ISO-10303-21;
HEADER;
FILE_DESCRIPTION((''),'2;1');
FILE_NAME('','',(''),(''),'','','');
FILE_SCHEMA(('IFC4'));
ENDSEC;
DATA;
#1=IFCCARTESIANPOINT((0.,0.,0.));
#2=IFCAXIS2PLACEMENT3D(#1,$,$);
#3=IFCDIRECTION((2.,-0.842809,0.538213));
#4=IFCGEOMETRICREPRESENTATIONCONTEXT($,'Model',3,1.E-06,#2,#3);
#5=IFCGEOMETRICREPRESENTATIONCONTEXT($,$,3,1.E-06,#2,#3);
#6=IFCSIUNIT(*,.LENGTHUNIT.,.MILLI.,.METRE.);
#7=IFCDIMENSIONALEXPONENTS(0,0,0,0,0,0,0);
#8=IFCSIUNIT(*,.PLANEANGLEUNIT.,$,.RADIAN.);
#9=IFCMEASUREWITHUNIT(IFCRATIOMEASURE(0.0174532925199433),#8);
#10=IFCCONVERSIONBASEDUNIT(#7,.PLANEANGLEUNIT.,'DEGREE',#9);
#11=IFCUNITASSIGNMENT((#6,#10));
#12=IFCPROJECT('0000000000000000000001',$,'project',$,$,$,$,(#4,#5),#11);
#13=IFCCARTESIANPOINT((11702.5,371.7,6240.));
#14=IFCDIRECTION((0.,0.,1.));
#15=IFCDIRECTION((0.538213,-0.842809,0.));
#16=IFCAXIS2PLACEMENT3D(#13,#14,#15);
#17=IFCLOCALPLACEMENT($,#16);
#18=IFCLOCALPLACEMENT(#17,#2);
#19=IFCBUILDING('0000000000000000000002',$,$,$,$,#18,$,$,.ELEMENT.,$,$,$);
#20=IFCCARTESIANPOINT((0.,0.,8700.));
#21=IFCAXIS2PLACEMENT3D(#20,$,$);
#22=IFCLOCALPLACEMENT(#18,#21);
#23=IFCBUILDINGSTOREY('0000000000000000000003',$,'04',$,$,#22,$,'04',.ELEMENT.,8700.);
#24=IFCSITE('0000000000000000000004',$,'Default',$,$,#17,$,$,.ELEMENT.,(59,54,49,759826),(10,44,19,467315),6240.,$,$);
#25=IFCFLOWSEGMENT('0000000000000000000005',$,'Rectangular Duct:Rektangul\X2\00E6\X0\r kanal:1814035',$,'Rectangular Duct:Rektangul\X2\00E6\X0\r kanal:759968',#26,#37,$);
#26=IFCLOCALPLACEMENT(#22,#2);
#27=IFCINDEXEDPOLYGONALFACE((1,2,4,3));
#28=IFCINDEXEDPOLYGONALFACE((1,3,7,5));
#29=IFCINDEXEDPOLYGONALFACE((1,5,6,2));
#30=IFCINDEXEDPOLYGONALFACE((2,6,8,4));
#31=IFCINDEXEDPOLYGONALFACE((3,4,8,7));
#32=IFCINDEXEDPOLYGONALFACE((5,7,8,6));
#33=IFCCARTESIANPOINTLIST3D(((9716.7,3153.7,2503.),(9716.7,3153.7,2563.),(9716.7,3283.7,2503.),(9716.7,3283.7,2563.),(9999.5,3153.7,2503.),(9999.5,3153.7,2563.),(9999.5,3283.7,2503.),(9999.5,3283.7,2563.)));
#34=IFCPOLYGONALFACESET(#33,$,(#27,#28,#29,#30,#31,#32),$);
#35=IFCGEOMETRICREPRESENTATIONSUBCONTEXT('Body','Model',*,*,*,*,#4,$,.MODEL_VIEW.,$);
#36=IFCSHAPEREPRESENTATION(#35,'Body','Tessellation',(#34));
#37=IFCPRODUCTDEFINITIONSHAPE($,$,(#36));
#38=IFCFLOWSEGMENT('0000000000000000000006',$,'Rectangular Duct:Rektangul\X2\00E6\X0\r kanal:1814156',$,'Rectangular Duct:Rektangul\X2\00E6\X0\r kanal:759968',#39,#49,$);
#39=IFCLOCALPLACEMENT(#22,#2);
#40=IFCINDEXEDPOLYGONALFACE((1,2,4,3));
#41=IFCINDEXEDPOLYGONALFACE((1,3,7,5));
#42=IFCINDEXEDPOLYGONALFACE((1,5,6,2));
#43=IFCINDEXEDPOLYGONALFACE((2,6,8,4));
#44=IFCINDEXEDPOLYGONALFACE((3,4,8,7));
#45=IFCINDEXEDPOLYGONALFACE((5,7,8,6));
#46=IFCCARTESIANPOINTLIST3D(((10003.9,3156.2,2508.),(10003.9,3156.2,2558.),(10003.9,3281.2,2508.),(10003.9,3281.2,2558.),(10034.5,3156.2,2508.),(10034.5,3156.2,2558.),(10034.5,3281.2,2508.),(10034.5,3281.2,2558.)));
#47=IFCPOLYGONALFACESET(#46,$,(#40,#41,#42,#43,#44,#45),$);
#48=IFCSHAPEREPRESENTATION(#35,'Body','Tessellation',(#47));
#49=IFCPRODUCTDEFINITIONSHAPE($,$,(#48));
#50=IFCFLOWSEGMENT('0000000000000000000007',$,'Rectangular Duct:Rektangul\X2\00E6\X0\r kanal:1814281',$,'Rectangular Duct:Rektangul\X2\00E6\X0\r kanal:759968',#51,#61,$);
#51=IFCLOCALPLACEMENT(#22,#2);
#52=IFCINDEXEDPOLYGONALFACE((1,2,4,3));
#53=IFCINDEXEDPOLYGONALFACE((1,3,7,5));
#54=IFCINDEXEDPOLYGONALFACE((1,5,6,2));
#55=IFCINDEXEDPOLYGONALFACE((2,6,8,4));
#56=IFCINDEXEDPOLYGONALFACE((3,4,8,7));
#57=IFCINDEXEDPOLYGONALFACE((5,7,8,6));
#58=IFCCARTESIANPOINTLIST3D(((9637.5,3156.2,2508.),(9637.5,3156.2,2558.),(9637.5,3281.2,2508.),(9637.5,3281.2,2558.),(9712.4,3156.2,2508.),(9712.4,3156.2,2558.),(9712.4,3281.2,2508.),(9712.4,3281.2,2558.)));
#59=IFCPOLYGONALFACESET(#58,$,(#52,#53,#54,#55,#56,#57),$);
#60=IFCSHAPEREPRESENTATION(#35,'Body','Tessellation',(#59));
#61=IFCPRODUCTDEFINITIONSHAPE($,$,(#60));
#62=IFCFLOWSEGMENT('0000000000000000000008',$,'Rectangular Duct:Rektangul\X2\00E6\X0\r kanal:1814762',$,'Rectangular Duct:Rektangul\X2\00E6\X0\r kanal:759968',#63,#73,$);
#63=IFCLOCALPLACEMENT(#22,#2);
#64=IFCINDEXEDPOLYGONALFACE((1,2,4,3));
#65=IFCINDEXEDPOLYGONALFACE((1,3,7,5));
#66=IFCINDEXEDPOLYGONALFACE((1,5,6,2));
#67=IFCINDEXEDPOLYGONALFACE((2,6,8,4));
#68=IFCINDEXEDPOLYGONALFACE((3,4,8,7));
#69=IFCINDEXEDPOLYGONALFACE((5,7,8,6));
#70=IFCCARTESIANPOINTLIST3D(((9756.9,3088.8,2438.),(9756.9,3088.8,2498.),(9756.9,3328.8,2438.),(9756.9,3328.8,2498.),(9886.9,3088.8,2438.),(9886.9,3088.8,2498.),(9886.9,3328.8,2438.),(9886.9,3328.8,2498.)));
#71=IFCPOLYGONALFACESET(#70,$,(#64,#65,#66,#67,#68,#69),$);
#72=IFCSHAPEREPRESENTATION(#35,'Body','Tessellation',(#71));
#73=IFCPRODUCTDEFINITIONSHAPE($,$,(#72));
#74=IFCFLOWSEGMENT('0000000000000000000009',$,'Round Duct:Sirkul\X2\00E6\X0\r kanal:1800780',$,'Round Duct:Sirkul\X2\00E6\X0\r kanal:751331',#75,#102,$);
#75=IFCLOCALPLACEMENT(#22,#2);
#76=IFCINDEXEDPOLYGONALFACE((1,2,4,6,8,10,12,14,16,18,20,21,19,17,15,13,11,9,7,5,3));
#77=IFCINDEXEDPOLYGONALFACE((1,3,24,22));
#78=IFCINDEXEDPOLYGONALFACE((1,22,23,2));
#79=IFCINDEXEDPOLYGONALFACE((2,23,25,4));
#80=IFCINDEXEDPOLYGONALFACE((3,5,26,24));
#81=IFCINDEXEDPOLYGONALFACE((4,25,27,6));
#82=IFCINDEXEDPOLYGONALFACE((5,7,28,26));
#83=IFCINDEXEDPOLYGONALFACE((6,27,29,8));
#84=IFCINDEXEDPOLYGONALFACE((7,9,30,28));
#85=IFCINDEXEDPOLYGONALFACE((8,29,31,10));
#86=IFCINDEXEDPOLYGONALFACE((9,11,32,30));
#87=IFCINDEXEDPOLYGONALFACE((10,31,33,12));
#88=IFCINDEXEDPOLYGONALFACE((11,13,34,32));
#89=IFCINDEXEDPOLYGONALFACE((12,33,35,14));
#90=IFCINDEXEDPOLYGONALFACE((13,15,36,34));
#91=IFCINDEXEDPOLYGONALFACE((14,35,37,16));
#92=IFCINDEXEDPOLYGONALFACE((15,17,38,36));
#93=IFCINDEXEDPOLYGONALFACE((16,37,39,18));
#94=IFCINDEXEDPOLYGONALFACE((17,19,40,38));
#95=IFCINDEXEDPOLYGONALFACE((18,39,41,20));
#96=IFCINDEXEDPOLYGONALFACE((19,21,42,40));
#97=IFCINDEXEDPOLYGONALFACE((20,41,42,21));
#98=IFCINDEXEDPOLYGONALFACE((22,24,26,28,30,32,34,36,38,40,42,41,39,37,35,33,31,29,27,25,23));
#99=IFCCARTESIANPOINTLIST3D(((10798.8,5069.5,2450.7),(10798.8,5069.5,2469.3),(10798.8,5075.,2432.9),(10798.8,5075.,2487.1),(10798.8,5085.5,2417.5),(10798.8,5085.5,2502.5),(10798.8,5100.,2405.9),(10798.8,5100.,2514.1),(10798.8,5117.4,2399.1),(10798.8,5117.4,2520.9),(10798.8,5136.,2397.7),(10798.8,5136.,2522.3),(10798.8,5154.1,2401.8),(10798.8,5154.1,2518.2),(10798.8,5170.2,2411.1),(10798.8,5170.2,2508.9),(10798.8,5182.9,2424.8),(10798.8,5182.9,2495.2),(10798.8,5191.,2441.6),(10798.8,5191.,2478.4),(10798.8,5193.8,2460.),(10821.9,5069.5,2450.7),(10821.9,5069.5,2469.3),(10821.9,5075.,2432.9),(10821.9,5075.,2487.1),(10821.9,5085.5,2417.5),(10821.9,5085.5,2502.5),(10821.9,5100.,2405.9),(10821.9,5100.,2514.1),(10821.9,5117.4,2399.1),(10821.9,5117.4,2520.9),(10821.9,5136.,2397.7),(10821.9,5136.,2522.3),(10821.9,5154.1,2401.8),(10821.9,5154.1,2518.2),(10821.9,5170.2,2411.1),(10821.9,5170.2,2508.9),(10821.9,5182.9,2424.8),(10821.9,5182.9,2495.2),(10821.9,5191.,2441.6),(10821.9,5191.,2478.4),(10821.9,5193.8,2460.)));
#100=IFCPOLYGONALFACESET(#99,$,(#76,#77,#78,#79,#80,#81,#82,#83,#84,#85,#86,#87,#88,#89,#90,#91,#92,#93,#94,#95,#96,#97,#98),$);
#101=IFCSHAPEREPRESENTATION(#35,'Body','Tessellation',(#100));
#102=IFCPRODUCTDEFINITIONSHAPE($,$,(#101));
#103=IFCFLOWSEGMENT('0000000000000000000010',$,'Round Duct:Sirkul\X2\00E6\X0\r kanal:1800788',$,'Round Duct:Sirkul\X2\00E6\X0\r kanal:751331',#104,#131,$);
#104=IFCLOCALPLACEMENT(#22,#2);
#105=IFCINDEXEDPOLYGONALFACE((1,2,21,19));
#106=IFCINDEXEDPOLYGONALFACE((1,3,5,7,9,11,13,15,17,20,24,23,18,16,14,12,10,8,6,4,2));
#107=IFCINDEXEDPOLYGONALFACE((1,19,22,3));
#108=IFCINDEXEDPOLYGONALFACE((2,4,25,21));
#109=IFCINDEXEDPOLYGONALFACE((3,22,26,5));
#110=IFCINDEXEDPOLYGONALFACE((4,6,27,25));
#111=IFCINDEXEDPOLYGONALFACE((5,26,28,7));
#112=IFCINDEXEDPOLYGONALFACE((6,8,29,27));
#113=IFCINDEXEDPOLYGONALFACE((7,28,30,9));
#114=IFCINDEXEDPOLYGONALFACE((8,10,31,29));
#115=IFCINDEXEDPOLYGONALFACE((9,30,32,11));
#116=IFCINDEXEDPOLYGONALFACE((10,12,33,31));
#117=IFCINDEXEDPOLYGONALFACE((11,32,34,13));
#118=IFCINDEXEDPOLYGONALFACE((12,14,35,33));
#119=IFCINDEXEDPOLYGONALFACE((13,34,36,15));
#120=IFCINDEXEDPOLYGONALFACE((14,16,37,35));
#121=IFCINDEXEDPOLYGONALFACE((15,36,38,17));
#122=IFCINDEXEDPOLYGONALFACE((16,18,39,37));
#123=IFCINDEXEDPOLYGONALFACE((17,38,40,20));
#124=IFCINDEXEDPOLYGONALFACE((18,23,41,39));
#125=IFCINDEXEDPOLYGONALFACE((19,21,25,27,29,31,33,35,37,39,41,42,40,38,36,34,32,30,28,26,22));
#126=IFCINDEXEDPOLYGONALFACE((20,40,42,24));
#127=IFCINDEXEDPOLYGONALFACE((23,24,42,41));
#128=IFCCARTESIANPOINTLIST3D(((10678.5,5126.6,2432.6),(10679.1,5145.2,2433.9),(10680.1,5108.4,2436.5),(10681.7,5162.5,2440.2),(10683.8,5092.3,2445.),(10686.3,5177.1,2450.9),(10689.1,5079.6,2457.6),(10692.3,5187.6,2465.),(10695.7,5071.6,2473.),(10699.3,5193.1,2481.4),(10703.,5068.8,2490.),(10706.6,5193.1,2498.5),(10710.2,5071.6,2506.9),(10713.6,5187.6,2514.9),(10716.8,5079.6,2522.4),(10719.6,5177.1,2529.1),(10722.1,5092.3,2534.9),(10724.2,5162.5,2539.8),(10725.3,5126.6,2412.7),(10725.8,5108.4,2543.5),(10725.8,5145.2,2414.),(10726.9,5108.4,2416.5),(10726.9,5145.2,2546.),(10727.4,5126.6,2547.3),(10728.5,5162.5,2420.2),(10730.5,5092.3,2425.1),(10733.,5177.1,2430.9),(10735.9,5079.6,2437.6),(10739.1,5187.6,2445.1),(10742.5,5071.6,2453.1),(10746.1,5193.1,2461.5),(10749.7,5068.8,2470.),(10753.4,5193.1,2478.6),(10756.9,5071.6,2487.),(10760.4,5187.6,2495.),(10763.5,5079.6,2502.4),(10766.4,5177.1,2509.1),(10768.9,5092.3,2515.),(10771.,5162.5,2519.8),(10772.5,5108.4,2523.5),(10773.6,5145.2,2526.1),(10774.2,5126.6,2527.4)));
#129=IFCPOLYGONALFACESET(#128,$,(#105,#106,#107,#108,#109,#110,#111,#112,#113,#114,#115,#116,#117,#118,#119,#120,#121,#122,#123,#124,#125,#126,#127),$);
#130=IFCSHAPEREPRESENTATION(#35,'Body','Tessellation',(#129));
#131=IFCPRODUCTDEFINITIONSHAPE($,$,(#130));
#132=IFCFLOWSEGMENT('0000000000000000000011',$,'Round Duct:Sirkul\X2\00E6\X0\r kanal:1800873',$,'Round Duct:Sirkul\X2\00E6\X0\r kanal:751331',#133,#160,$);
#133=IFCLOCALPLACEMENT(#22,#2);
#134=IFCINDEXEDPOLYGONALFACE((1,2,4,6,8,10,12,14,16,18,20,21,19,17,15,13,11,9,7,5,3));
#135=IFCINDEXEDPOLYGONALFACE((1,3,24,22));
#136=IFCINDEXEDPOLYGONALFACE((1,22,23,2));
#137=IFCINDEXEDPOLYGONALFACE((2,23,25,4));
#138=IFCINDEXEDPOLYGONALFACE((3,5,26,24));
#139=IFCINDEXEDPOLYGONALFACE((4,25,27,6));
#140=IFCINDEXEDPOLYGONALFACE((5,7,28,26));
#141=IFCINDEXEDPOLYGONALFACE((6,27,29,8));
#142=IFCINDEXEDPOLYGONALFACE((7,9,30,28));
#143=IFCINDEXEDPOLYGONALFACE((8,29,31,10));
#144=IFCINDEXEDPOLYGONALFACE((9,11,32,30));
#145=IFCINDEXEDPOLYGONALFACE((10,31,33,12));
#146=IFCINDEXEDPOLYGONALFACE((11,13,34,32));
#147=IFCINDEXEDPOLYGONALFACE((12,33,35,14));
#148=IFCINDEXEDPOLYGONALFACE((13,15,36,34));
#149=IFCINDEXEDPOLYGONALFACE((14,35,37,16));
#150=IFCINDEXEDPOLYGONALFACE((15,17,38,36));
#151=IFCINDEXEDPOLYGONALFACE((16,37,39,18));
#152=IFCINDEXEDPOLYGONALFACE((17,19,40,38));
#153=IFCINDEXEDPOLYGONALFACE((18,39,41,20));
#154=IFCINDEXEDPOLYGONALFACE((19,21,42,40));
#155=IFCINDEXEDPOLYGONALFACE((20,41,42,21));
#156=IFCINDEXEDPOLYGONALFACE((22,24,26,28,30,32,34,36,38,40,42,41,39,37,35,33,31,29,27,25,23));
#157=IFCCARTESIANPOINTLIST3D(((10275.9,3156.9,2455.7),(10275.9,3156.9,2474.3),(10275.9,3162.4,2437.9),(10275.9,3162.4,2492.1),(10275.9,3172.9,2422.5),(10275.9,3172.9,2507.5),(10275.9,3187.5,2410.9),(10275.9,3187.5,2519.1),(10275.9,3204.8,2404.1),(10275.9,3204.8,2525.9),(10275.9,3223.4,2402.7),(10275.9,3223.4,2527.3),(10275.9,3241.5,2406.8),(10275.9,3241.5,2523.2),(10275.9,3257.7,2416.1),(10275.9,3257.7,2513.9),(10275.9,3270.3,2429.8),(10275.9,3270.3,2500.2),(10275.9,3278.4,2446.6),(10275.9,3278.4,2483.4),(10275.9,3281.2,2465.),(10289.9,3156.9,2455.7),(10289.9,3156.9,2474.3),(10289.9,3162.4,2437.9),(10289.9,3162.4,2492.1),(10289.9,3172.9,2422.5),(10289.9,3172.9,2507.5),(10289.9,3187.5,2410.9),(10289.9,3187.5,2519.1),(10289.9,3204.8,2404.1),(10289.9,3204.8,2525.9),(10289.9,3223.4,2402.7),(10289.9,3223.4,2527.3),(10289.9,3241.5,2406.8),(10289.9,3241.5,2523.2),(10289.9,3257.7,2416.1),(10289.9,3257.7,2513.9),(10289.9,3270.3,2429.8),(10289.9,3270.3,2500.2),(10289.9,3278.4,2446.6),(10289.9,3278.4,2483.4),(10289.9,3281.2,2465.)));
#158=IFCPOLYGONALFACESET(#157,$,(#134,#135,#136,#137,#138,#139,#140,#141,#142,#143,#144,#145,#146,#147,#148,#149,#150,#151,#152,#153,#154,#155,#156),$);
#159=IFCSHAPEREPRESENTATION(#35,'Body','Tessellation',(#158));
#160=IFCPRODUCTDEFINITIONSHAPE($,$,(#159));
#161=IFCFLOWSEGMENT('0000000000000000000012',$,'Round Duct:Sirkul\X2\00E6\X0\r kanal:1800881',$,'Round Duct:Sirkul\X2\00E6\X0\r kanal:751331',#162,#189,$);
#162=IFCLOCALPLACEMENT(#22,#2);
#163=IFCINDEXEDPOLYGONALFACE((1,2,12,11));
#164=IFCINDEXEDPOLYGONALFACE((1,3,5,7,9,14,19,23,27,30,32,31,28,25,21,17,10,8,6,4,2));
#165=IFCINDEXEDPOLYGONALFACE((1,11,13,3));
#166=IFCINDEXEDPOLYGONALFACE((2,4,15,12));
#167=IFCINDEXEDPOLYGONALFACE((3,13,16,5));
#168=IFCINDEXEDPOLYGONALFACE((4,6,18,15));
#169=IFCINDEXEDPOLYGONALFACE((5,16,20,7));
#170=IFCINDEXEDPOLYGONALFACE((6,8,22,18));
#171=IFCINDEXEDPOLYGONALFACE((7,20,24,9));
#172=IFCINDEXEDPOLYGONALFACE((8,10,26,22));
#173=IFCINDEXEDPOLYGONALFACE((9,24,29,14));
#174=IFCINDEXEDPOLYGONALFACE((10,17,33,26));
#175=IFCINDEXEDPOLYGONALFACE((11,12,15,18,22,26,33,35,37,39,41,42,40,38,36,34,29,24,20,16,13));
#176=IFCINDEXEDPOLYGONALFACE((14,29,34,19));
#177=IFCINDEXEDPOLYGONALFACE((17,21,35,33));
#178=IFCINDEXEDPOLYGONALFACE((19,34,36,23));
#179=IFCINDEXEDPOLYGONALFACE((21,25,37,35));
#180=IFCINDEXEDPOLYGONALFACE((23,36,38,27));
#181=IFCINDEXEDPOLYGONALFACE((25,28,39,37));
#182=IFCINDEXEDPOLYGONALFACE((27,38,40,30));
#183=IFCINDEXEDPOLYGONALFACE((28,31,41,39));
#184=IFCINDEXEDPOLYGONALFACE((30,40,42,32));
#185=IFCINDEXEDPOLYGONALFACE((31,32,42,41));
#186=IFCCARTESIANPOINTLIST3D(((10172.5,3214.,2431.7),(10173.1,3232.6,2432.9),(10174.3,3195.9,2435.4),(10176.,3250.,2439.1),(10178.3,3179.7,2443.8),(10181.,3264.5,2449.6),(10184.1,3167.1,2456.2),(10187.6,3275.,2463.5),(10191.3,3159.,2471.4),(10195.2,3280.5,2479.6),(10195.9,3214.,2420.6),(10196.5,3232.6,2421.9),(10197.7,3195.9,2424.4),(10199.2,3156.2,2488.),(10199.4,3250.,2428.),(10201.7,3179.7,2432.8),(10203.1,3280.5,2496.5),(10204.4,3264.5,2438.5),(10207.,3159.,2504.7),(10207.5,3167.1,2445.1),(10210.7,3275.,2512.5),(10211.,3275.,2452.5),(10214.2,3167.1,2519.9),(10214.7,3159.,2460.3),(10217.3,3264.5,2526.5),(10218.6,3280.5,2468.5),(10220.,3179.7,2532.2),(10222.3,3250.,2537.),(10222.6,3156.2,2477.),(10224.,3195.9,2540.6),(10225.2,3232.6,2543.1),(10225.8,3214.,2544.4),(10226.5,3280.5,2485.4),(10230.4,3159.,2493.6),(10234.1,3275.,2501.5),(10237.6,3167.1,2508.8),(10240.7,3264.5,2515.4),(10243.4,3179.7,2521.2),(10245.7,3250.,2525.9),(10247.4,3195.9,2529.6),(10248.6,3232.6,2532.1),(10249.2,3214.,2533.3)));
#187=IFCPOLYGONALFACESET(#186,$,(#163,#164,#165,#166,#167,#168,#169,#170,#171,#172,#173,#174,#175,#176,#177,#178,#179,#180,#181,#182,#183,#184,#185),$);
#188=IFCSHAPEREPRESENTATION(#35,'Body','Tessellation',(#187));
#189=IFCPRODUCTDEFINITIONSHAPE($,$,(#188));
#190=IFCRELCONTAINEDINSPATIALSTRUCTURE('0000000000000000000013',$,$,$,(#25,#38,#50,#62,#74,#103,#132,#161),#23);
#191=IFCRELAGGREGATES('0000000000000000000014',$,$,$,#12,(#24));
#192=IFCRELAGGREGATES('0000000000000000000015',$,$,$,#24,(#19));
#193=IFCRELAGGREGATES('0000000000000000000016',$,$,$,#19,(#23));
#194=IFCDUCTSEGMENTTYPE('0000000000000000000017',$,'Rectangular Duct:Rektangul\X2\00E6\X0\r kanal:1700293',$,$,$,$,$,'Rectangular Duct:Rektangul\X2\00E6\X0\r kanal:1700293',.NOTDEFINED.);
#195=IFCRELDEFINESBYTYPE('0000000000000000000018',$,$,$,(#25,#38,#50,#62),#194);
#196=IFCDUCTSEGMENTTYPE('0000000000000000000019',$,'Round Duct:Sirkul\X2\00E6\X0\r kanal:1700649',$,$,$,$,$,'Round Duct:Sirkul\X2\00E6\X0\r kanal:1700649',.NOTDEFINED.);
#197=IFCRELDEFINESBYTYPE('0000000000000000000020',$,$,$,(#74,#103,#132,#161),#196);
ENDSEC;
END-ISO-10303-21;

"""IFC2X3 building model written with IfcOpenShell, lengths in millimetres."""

from ifc_helpers import new_model, entity, si_unit, converted_unit, direction, frame, frame_2d, origin, origin_2d_with_axis, place, context, subcontext, project, spatial, rectangle, circle, extrude, type_object, element, save


model = new_model("IFC2X3")

# Units and contexts
model_context = context("Model", 3, precision=1e-06, world=origin(), true_north=direction((2.0, -0.842809, 0.538213)))
context_of_model = context(None, 3, precision=1e-06, world=origin(), true_north=direction((2.0, -0.842809, 0.538213)))
body_context = subcontext(model_context, "Body", "Model", "MODEL_VIEW")
ifc_project = project(units=[si_unit("LENGTHUNIT", "METRE", prefix="MILLI"), converted_unit("PLANEANGLEUNIT", "DEGREE", entity("IfcRatioMeasure", 0.0174532925199433), si_unit("PLANEANGLEUNIT", "RADIAN"), dimensions=[0, 0, 0, 0, 0, 0, 0])], contexts=[model_context, context_of_model])

# Site, building, storey
site_placement = place(None, frame((11702.5, 371.7, 6240.0), z_axis=(0.0, 0.0, 1.0), x_axis=(0.538213, -0.842809, 0.0)))
site = spatial("IfcSite", under=ifc_project, at=site_placement, Name="Default", CompositionType="ELEMENT", RefLatitude=(59, 54, 49, 759826), RefLongitude=(10, 44, 19, 467315), RefElevation=6240.0)
building_placement = place(site_placement, origin())
building = spatial("IfcBuilding", under=site, at=building_placement, CompositionType="ELEMENT")
storey_placement = place(building_placement, frame((0.0, 0.0, 8700.0)))
storey = spatial("IfcBuildingStorey", under=building, at=storey_placement, Name="04", LongName="04", CompositionType="ELEMENT", Elevation=8700.0)

# Flow segments
duct_segment_type_1 = type_object("IfcDuctSegmentType", Name="Rectangular Duct:Rektangulær kanal:1700293", ElementType="Rectangular Duct:Rektangulær kanal:1700293", PredefinedType="NOTDEFINED")
flow_segment_1_placement = place(storey_placement, origin())
element("IfcFlowSegment", 1, at=flow_segment_1_placement, inside=storey, type_object=duct_segment_type_1, Name="Rectangular Duct:Rektangulær kanal:1814035", ObjectType="Rectangular Duct:Rektangulær kanal:759968", context=body_context, shape_type="SweptSolid", body=[
    extrude(rectangle(XDim=282.8, YDim=130.0, at=frame_2d((0.0, 0.0), x_axis=(1.0, 0.0))), frame((9858.1, 3218.7, 2503.0)), (0.0, 0.0, 1.0), 60.0),
])
flow_segment_2_placement = place(storey_placement, origin())
element("IfcFlowSegment", 2, at=flow_segment_2_placement, inside=storey, type_object=duct_segment_type_1, Name="Rectangular Duct:Rektangulær kanal:1814156", ObjectType="Rectangular Duct:Rektangulær kanal:759968", context=body_context, shape_type="SweptSolid", body=[
    extrude(rectangle(XDim=30.7, YDim=125.0, at=frame_2d((0.0, 0.0), x_axis=(1.0, 0.0))), frame((10019.2, 3218.7, 2508.0), z_axis=(0.0, 0.0, 1.0), x_axis=(-1.0, 0.0, 0.0)), (0.0, 0.0, 1.0), 50.0),
])
flow_segment_3_placement = place(storey_placement, origin())
element("IfcFlowSegment", 3, at=flow_segment_3_placement, inside=storey, type_object=duct_segment_type_1, Name="Rectangular Duct:Rektangulær kanal:1814281", ObjectType="Rectangular Duct:Rektangulær kanal:759968", context=body_context, shape_type="SweptSolid", body=[
    extrude(rectangle(XDim=74.9, YDim=125.0, at=origin_2d_with_axis()), frame((9674.9, 3218.7, 2508.0)), (0.0, 0.0, 1.0), 50.0),
])
flow_segment_4_placement = place(storey_placement, origin())
element("IfcFlowSegment", 4, at=flow_segment_4_placement, inside=storey, type_object=duct_segment_type_1, Name="Rectangular Duct:Rektangulær kanal:1814762", ObjectType="Rectangular Duct:Rektangulær kanal:759968", context=body_context, shape_type="SweptSolid", body=[
    extrude(rectangle(XDim=240.0, YDim=130.0, at=frame_2d((0.0, 0.0), x_axis=(1.0, 0.0))), frame((9821.9, 3208.8, 2438.0), z_axis=(0.0, 0.0, 1.0), x_axis=(0.0, -1.0, 0.0)), (0.0, 0.0, 1.0), 60.0),
])
duct_segment_type_2 = type_object("IfcDuctSegmentType", Name="Round Duct:Sirkulær kanal:1700649", ElementType="Round Duct:Sirkulær kanal:1700649", PredefinedType="NOTDEFINED")
flow_segment_5_placement = place(storey_placement, origin())
element("IfcFlowSegment", 5, at=flow_segment_5_placement, inside=storey, type_object=duct_segment_type_2, Name="Round Duct:Sirkulær kanal:1800780", ObjectType="Round Duct:Sirkulær kanal:751331", context=body_context, shape_type="SweptSolid", body=[
    extrude(circle(Radius=62.5, at=origin_2d_with_axis()), frame((10798.8, 5131.3, 2460.0), z_axis=(1.0, 0.0, 0.0), x_axis=(0.0, 1.0, 0.0)), (0.0, 0.0, 1.0), 23.1),
])
flow_segment_6_placement = place(storey_placement, origin())
element("IfcFlowSegment", 6, at=flow_segment_6_placement, inside=storey, type_object=duct_segment_type_2, Name="Round Duct:Sirkulær kanal:1800788", ObjectType="Round Duct:Sirkulær kanal:751331", context=body_context, shape_type="SweptSolid", body=[
    extrude(circle(Radius=62.5, at=origin_2d_with_axis()), frame((10749.7, 5131.3, 2470.0), z_axis=(-0.91979, 0.0, 0.392411), x_axis=(0.0, -1.0, 0.0)), (0.0, 0.0, 1.0), 50.8),
])
flow_segment_7_placement = place(storey_placement, origin())
element("IfcFlowSegment", 7, at=flow_segment_7_placement, inside=storey, type_object=duct_segment_type_2, Name="Round Duct:Sirkulær kanal:1800873", ObjectType="Round Duct:Sirkulær kanal:751331", context=body_context, shape_type="SweptSolid", body=[
    extrude(circle(Radius=62.5, at=origin_2d_with_axis()), frame((10275.9, 3218.7, 2465.0), z_axis=(1.0, 0.0, 0.0), x_axis=(0.0, 1.0, 0.0)), (0.0, 0.0, 1.0), 13.9),
])
flow_segment_8_placement = place(storey_placement, origin())
element("IfcFlowSegment", 8, at=flow_segment_8_placement, inside=storey, type_object=duct_segment_type_2, Name="Round Duct:Sirkulær kanal:1800881", ObjectType="Round Duct:Sirkulær kanal:751331", context=body_context, shape_type="SweptSolid", body=[
    extrude(circle(Radius=62.5, at=origin_2d_with_axis()), frame((10222.6, 3218.7, 2477.0), z_axis=(-0.904222, 0.0, 0.427062), x_axis=(0.0, -1.0, 0.0)), (0.0, 0.0, 1.0), 25.9),
])

save(model, "model.ifc")
